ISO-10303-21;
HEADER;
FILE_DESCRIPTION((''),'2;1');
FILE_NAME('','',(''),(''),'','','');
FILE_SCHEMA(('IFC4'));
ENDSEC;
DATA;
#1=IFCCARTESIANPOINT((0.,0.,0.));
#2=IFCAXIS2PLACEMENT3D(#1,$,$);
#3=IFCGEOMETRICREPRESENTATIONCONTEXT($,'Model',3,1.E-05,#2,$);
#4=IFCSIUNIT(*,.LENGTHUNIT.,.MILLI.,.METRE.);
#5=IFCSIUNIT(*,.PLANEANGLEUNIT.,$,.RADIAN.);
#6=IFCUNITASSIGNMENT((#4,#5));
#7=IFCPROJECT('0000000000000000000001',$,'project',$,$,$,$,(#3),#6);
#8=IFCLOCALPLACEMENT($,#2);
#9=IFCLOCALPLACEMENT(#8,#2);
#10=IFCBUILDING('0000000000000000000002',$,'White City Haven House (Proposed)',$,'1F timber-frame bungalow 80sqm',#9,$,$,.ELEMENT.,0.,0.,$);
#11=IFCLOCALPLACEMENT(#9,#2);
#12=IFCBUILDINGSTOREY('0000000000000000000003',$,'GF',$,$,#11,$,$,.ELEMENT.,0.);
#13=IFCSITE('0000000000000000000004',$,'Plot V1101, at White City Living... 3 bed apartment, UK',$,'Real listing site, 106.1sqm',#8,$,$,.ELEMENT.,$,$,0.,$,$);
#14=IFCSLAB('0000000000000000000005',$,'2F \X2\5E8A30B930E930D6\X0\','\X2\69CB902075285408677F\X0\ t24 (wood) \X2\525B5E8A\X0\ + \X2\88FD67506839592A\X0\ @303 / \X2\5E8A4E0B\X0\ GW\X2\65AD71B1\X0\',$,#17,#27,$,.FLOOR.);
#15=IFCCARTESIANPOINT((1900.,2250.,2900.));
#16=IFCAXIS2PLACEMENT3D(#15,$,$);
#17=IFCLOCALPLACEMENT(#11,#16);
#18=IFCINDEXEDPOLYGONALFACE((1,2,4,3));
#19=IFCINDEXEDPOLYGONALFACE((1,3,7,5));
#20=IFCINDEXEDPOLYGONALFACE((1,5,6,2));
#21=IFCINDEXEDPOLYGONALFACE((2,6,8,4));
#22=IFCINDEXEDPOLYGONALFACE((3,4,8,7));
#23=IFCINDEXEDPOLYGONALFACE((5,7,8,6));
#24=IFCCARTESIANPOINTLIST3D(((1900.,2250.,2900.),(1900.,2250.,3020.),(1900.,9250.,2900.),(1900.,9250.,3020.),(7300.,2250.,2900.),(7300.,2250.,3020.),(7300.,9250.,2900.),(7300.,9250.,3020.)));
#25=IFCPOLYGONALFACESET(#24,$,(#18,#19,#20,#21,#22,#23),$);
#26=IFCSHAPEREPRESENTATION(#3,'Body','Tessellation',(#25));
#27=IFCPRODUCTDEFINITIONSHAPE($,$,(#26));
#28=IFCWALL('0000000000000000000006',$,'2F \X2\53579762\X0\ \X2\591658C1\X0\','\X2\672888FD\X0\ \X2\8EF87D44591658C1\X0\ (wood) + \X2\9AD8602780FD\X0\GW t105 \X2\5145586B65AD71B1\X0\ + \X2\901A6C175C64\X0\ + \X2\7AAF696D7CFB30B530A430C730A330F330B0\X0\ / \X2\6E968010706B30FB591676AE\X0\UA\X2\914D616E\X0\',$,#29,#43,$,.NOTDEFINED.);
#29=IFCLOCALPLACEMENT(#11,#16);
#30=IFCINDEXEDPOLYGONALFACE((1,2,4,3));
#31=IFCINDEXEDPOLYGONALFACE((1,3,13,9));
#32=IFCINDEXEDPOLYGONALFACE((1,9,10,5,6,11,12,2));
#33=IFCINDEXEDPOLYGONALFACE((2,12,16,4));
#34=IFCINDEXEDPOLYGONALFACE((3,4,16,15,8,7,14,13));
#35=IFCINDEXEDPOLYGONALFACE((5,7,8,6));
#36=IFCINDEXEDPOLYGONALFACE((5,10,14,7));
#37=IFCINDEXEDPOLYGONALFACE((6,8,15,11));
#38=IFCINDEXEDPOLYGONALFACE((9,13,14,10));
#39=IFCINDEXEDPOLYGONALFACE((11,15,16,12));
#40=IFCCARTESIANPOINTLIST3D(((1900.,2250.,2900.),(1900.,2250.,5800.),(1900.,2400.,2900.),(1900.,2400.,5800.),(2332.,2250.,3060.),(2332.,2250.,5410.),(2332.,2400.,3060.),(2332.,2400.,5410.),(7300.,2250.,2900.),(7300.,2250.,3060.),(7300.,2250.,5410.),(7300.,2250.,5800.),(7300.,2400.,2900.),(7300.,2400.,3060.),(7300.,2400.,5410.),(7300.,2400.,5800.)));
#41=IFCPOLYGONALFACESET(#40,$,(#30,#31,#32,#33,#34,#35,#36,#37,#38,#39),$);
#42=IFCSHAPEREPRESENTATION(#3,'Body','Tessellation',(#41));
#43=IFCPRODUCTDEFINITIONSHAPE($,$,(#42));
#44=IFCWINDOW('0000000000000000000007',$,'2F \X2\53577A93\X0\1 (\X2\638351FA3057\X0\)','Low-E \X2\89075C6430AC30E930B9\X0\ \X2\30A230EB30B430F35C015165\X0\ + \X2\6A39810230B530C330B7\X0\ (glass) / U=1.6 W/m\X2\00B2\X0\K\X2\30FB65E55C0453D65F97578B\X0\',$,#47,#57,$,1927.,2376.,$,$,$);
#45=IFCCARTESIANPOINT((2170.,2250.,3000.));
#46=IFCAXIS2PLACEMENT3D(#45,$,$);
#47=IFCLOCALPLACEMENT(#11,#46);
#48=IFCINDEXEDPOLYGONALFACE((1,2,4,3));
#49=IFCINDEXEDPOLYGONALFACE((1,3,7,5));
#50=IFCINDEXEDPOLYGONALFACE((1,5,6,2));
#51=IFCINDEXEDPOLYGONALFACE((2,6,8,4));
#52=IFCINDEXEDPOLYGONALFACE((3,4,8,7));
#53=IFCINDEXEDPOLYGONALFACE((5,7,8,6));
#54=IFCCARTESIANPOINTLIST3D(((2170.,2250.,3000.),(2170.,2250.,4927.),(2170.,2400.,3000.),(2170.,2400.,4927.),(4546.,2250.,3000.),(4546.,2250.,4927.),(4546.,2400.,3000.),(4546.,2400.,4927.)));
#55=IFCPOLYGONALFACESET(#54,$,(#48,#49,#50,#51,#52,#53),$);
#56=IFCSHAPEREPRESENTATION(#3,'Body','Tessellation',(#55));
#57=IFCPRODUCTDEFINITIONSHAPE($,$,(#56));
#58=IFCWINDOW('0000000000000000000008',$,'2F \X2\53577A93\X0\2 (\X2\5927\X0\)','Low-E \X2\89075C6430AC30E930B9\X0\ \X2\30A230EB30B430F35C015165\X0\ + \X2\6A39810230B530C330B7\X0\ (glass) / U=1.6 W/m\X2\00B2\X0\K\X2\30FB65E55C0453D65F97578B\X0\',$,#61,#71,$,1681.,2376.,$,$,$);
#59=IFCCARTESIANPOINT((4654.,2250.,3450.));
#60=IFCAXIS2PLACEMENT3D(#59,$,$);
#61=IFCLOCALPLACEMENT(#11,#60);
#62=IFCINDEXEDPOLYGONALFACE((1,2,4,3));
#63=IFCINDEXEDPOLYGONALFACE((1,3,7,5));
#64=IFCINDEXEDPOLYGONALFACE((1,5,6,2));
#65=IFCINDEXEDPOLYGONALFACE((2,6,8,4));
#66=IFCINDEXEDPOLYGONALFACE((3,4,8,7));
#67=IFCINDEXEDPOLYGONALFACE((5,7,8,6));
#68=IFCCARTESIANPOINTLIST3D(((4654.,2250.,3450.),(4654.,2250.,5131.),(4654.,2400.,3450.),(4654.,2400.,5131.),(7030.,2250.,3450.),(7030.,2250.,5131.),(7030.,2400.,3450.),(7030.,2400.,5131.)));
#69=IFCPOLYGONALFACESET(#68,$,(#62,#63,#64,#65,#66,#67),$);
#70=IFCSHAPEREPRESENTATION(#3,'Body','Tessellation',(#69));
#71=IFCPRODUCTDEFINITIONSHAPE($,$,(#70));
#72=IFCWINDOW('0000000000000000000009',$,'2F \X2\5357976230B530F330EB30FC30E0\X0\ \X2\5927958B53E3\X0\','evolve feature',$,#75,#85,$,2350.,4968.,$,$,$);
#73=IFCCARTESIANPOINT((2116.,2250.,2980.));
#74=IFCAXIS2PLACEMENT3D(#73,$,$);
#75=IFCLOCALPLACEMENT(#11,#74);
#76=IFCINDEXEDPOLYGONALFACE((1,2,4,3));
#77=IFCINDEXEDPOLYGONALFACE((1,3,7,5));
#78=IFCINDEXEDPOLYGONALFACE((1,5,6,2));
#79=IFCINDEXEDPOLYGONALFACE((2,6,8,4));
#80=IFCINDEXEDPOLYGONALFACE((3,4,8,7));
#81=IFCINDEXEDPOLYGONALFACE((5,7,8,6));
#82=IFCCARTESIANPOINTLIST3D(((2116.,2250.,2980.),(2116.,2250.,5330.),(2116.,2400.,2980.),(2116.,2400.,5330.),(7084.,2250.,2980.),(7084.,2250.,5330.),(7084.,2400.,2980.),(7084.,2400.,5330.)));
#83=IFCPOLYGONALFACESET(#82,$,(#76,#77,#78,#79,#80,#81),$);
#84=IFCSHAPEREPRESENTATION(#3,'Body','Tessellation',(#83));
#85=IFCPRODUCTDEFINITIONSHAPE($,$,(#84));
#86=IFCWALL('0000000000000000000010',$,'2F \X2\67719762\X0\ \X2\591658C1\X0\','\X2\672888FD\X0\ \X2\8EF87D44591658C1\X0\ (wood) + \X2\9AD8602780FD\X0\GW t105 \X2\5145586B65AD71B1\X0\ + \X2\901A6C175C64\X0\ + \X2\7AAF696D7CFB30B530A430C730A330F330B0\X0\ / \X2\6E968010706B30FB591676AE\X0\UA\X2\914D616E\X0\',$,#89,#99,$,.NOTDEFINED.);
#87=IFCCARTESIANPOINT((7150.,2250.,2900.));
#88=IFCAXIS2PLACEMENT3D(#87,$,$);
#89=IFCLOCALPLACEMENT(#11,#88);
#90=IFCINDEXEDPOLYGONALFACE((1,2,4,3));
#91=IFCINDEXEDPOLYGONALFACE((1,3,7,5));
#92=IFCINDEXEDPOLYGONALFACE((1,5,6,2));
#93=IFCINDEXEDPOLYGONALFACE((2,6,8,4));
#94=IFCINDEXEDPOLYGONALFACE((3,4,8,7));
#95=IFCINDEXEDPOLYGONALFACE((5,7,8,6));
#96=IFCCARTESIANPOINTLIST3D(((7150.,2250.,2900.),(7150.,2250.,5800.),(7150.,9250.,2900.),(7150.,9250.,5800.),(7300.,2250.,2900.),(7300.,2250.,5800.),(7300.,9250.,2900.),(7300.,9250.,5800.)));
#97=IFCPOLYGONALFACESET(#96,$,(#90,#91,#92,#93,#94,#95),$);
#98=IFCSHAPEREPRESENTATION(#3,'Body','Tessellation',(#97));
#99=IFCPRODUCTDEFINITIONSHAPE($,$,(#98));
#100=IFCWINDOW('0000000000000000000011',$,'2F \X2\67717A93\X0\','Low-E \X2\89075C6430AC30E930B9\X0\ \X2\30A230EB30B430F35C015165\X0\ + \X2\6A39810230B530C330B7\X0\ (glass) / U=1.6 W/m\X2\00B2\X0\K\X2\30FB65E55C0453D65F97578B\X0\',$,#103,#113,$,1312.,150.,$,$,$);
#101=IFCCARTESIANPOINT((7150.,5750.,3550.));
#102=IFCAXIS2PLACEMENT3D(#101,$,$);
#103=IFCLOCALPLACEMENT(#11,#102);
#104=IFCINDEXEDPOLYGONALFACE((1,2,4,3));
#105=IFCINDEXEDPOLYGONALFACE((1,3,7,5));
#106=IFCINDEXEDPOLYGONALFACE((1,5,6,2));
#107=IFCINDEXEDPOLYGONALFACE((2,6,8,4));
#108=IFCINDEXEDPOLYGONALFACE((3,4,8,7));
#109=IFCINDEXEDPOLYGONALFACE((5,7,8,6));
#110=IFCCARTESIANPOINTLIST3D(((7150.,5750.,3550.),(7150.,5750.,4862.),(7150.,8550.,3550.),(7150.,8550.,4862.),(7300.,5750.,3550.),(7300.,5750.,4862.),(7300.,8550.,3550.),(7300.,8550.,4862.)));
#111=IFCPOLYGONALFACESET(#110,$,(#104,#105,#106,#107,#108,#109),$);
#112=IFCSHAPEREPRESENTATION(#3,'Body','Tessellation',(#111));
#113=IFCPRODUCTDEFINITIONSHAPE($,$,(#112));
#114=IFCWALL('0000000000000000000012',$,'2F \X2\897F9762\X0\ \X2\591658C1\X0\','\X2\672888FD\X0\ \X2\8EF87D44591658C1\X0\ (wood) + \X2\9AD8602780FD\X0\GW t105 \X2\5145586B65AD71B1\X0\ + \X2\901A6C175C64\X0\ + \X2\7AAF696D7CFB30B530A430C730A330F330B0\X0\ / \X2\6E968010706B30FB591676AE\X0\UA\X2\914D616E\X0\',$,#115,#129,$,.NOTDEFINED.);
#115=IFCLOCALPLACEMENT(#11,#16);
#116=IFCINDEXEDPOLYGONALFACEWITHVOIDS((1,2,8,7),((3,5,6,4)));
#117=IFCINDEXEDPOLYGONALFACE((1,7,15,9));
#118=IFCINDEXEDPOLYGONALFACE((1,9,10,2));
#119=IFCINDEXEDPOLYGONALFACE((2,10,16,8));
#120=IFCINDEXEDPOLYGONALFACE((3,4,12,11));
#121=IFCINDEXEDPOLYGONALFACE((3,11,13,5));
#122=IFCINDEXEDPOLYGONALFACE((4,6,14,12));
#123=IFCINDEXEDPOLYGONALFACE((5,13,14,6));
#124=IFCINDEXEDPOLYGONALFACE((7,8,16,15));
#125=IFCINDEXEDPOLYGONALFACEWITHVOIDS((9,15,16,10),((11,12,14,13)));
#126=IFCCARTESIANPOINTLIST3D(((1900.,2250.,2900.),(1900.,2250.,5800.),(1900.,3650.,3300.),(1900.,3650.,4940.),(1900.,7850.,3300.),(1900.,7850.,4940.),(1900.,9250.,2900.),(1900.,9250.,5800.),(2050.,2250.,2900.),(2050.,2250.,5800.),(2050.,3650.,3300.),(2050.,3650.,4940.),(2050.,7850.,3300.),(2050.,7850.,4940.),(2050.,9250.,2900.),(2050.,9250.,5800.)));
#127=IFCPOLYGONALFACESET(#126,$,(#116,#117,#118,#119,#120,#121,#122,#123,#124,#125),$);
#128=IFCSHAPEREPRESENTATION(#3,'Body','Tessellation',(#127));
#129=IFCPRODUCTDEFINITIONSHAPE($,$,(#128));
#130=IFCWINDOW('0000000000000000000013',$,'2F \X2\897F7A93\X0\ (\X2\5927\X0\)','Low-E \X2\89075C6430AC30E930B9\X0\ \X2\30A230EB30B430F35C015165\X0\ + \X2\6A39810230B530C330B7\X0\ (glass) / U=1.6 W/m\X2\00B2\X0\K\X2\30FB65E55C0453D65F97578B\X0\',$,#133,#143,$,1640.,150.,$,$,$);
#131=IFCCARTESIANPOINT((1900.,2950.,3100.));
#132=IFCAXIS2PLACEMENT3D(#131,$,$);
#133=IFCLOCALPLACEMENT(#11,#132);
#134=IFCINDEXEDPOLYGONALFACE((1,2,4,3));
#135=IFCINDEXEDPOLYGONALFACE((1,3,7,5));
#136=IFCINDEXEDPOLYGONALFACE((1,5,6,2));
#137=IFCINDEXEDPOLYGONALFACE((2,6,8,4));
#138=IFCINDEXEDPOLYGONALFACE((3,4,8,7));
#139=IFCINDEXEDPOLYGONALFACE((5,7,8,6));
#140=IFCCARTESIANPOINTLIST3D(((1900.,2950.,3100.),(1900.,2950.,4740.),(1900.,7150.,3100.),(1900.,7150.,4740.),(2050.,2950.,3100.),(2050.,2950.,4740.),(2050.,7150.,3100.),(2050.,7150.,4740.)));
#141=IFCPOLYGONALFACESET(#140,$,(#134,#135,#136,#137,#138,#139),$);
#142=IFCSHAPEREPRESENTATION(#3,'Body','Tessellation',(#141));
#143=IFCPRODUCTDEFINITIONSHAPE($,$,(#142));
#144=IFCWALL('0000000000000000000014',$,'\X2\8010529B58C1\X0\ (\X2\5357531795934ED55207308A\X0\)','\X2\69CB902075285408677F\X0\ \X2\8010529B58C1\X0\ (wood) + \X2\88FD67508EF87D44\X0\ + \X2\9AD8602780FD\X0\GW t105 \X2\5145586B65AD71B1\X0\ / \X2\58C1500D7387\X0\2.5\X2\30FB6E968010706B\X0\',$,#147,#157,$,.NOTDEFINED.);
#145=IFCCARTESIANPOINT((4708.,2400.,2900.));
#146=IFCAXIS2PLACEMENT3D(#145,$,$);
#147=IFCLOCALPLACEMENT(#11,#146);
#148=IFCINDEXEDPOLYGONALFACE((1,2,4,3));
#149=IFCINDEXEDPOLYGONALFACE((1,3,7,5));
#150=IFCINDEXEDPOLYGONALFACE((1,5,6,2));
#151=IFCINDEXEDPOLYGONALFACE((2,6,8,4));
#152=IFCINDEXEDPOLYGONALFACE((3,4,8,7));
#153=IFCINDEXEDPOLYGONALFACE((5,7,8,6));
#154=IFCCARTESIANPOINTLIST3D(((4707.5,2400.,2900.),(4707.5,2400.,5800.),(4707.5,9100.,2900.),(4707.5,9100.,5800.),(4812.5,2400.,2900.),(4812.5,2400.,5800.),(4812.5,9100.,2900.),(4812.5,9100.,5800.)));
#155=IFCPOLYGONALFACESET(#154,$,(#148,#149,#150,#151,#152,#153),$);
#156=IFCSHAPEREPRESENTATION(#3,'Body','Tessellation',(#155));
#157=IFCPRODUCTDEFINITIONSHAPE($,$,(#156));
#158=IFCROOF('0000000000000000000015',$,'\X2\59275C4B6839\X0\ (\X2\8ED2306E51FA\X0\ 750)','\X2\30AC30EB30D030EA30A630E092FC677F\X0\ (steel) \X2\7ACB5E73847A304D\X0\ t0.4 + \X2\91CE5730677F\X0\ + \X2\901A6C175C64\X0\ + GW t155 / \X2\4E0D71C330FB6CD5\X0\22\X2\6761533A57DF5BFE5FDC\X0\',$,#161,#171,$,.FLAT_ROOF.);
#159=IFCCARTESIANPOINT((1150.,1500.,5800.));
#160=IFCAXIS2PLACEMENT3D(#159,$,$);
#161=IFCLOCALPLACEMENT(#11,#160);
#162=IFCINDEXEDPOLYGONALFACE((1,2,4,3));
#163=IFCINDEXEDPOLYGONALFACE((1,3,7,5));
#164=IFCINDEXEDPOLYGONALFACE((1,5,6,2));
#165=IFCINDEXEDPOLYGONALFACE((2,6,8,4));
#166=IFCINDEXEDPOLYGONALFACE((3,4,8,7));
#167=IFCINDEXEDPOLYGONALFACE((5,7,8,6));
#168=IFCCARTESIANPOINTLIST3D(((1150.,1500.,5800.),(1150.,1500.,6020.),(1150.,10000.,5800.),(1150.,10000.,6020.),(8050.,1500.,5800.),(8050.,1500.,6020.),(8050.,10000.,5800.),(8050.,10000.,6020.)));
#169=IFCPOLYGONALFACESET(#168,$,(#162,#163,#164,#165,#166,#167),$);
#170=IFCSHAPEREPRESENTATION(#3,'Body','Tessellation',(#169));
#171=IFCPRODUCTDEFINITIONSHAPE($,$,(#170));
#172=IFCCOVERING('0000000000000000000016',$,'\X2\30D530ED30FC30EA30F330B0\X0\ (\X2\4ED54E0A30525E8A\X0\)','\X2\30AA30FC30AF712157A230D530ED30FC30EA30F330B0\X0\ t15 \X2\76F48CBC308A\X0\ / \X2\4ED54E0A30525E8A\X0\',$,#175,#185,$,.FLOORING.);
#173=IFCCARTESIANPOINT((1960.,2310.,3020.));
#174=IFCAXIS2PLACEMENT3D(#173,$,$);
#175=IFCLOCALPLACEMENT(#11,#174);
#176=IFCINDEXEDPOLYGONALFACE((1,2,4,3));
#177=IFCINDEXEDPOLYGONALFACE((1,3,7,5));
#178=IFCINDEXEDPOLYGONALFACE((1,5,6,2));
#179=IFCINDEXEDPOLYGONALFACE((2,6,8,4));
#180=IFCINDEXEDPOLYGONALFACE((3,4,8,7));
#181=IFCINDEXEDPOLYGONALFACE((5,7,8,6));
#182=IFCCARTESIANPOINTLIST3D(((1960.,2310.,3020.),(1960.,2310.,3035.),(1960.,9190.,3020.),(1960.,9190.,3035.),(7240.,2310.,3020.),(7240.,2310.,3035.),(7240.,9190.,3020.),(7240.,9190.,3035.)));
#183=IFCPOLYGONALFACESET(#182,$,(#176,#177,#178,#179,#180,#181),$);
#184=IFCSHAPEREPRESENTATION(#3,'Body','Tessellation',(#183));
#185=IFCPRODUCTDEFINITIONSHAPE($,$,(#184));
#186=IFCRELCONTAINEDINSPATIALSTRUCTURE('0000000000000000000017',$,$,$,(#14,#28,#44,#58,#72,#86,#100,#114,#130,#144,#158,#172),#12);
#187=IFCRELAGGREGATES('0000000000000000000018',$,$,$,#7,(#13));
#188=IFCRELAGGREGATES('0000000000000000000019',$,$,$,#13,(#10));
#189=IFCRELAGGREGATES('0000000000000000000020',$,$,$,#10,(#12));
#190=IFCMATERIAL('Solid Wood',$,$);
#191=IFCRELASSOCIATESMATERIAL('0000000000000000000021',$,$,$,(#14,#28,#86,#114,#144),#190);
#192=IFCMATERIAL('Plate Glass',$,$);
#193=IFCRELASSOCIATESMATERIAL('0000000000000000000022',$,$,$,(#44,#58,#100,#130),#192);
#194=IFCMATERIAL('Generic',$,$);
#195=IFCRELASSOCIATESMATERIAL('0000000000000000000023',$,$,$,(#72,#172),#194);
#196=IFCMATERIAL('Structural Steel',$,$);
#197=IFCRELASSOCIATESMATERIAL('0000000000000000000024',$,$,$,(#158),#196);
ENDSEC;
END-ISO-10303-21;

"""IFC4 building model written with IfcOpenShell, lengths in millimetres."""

from ifc_helpers import new_model, si_unit, frame, frame_2d, origin, place, context, project, spatial, rectangle, extrude, material, element, fill, save


model = new_model("IFC4")

# Units and contexts
model_context = context("Model", 3, precision=1e-05, world=origin())
ifc_project = project(units=[si_unit("LENGTHUNIT", "METRE", prefix="MILLI"), si_unit("PLANEANGLEUNIT", "RADIAN")], contexts=[model_context])

# Site, building, storey
site_placement = place(None, origin())
site = spatial("IfcSite", under=ifc_project, at=site_placement, Name="Plot V1101, at White City Living... 3 bed apartment, UK", ObjectType="Real listing site, 106.1sqm", CompositionType="ELEMENT", RefElevation=0.0)
building_placement = place(site_placement, origin())
building = spatial("IfcBuilding", under=site, at=building_placement, Name="White City Haven House (Proposed)", ObjectType="1F timber-frame bungalow 80sqm", CompositionType="ELEMENT", ElevationOfRefHeight=0.0, ElevationOfTerrain=0.0)
storey_placement = place(building_placement, origin())
storey = spatial("IfcBuildingStorey", under=building, at=storey_placement, Name="GF", CompositionType="ELEMENT", Elevation=0.0)

# Slab
ifc_material_1 = material(Name="Solid Wood")
slab_placement = place(storey_placement, frame((1900.0, 2250.0, 2900.0)))
element("IfcSlab", 1, at=slab_placement, inside=storey, material=ifc_material_1, Name="2F 床スラブ", Description="構造用合板 t24 (wood) 剛床 + 製材根太 @303 / 床下 GW断熱", PredefinedType="FLOOR", context=model_context, shape_type="SweptSolid", body=[
    extrude(rectangle(XDim=5400.0, YDim=7000.0, at=frame_2d((2700.0, 3500.0))), frame((1900.0, 2250.0, 2900.0)), (0.0, 0.0, 1.0), 120.0),
])

# Wall, openings, windows
wall_1_placement = place(storey_placement, frame((1900.0, 2250.0, 2900.0)))
wall_1 = element("IfcWall", 2, at=wall_1_placement, inside=storey, material=ifc_material_1, Name="2F 南面 外壁", Description="木製 軸組外壁 (wood) + 高性能GW t105 充填断熱 + 通気層 + 窯業系サイディング / 準耐火・外皮UA配慮", PredefinedType="NOTDEFINED", context=model_context, shape_type="SweptSolid", body=[
    extrude(rectangle(XDim=5400.0, YDim=150.0, at=frame_2d((2700.0, 75.0))), frame((1900.0, 2250.0, 2900.0)), (0.0, 0.0, 1.0), 2900.0),
])
opening_1_placement = place(storey_placement, frame((2170.0, 2250.0, 3000.0)))
opening_1 = element("IfcOpeningElement", 3, at=opening_1_placement, cuts=wall_1, PredefinedType="NOTDEFINED", context=model_context, shape_type="SweptSolid", body=[
    extrude(rectangle(XDim=2376.0, YDim=150.0, at=frame_2d((1188.0, 75.0))), frame((2170.0, 2250.0, 3000.0)), (0.0, 0.0, 1.0), 1927.0),
])
opening_2_placement = place(storey_placement, frame((4654.0, 2250.0, 3450.0)))
opening_2 = element("IfcOpeningElement", 4, at=opening_2_placement, cuts=wall_1, PredefinedType="NOTDEFINED", context=model_context, shape_type="SweptSolid", body=[
    extrude(rectangle(XDim=2376.0, YDim=150.0, at=frame_2d((1188.0, 75.0))), frame((4654.0, 2250.0, 3450.0)), (0.0, 0.0, 1.0), 1681.0),
])
opening_3_placement = place(storey_placement, frame((2116.0, 2250.0, 2980.0)))
opening_3 = element("IfcOpeningElement", 5, at=opening_3_placement, cuts=wall_1, PredefinedType="NOTDEFINED", context=model_context, shape_type="SweptSolid", body=[
    extrude(rectangle(XDim=4968.0, YDim=150.0, at=frame_2d((2484.0, 75.0))), frame((2116.0, 2250.0, 2980.0)), (0.0, 0.0, 1.0), 2350.0),
])
ifc_material_2 = material(Name="Plate Glass")
window_1_placement = place(storey_placement, frame((2170.0, 2250.0, 3000.0)))
window_1 = element("IfcWindow", 6, at=window_1_placement, inside=storey, material=ifc_material_2, Name="2F 南窓1 (掃出し)", Description="Low-E 複層ガラス アルゴン封入 + 樹脂サッシ (glass) / U=1.6 W/m²K・日射取得型", OverallHeight=1927.0, OverallWidth=2376.0, context=model_context, shape_type="SweptSolid", body=[
    extrude(rectangle(XDim=2376.0, YDim=150.0, at=frame_2d((1188.0, 75.0))), frame((2170.0, 2250.0, 3000.0)), (0.0, 0.0, 1.0), 1927.0),
])
fill(opening_1, window_1)
window_2_placement = place(storey_placement, frame((4654.0, 2250.0, 3450.0)))
window_2 = element("IfcWindow", 7, at=window_2_placement, inside=storey, material=ifc_material_2, Name="2F 南窓2 (大)", Description="Low-E 複層ガラス アルゴン封入 + 樹脂サッシ (glass) / U=1.6 W/m²K・日射取得型", OverallHeight=1681.0, OverallWidth=2376.0, context=model_context, shape_type="SweptSolid", body=[
    extrude(rectangle(XDim=2376.0, YDim=150.0, at=frame_2d((1188.0, 75.0))), frame((4654.0, 2250.0, 3450.0)), (0.0, 0.0, 1.0), 1681.0),
])
fill(opening_2, window_2)
ifc_material_3 = material(Name="Generic")
window_3_placement = place(storey_placement, frame((2116.0, 2250.0, 2980.0)))
window_3 = element("IfcWindow", 8, at=window_3_placement, inside=storey, material=ifc_material_3, Name="2F 南面サンルーム 大開口", Description="evolve feature", OverallHeight=2350.0, OverallWidth=4968.0, context=model_context, shape_type="SweptSolid", body=[
    extrude(rectangle(XDim=4968.0, YDim=150.0, at=frame_2d((2484.0, 75.0))), frame((2116.0, 2250.0, 2980.0)), (0.0, 0.0, 1.0), 2350.0),
])
fill(opening_3, window_3)

# Walls, openings, windows
wall_2_placement = place(storey_placement, frame((7150.0, 2250.0, 2900.0)))
wall_2 = element("IfcWall", 9, at=wall_2_placement, inside=storey, material=ifc_material_1, Name="2F 東面 外壁", Description="木製 軸組外壁 (wood) + 高性能GW t105 充填断熱 + 通気層 + 窯業系サイディング / 準耐火・外皮UA配慮", PredefinedType="NOTDEFINED", context=model_context, shape_type="SweptSolid", body=[
    extrude(rectangle(XDim=150.0, YDim=7000.0, at=frame_2d((75.0, 3500.0))), frame((7150.0, 2250.0, 2900.0)), (0.0, 0.0, 1.0), 2900.0),
])
opening_4_placement = place(storey_placement, frame((7150.0, 5750.0, 3550.0)))
opening_4 = element("IfcOpeningElement", 10, at=opening_4_placement, cuts=wall_2, PredefinedType="NOTDEFINED", context=model_context, shape_type="SweptSolid", body=[
    extrude(rectangle(XDim=150.0, YDim=2800.0, at=frame_2d((75.0, 1400.0))), frame((7150.0, 5750.0, 3550.0)), (0.0, 0.0, 1.0), 1312.0),
])
window_4_placement = place(storey_placement, frame((7150.0, 5750.0, 3550.0)))
window_4 = element("IfcWindow", 11, at=window_4_placement, inside=storey, material=ifc_material_2, Name="2F 東窓", Description="Low-E 複層ガラス アルゴン封入 + 樹脂サッシ (glass) / U=1.6 W/m²K・日射取得型", OverallHeight=1312.0, OverallWidth=150.0, context=model_context, shape_type="SweptSolid", body=[
    extrude(rectangle(XDim=150.0, YDim=2800.0, at=frame_2d((75.0, 1400.0))), frame((7150.0, 5750.0, 3550.0)), (0.0, 0.0, 1.0), 1312.0),
])
fill(opening_4, window_4)
wall_3_placement = place(storey_placement, frame((1900.0, 2250.0, 2900.0)))
wall_3 = element("IfcWall", 12, at=wall_3_placement, inside=storey, material=ifc_material_1, Name="2F 西面 外壁", Description="木製 軸組外壁 (wood) + 高性能GW t105 充填断熱 + 通気層 + 窯業系サイディング / 準耐火・外皮UA配慮", PredefinedType="NOTDEFINED", context=model_context, shape_type="SweptSolid", body=[
    extrude(rectangle(XDim=150.0, YDim=7000.0, at=frame_2d((75.0, 3500.0))), frame((1900.0, 2250.0, 2900.0)), (0.0, 0.0, 1.0), 2900.0),
])
opening_5_placement = place(storey_placement, frame((1900.0, 2950.0, 3100.0)))
opening_5 = element("IfcOpeningElement", 13, at=opening_5_placement, cuts=wall_3, PredefinedType="NOTDEFINED", context=model_context, shape_type="SweptSolid", body=[
    extrude(rectangle(XDim=150.0, YDim=4200.0, at=frame_2d((75.0, 2100.0))), frame((1900.0, 2950.0, 3100.0)), (0.0, 0.0, 1.0), 1640.0),
])
window_5_placement = place(storey_placement, frame((1900.0, 2950.0, 3100.0)))
window_5 = element("IfcWindow", 14, at=window_5_placement, inside=storey, material=ifc_material_2, Name="2F 西窓 (大)", Description="Low-E 複層ガラス アルゴン封入 + 樹脂サッシ (glass) / U=1.6 W/m²K・日射取得型", OverallHeight=1640.0, OverallWidth=150.0, context=model_context, shape_type="SweptSolid", body=[
    extrude(rectangle(XDim=150.0, YDim=4200.0, at=frame_2d((75.0, 2100.0))), frame((1900.0, 2950.0, 3100.0)), (0.0, 0.0, 1.0), 1640.0),
])
fill(opening_5, window_5)

# Wall
wall_4_placement = place(storey_placement, frame((4708.0, 2400.0, 2900.0)))
element("IfcWall", 15, at=wall_4_placement, inside=storey, material=ifc_material_1, Name="耐力壁 (南北間仕切り)", Description="構造用合板 耐力壁 (wood) + 製材軸組 + 高性能GW t105 充填断熱 / 壁倍率2.5・準耐火", PredefinedType="NOTDEFINED", context=model_context, shape_type="SweptSolid", body=[
    extrude(rectangle(XDim=105.0, YDim=6700.0, at=frame_2d((52.0, 3350.0))), frame((4708.0, 2400.0, 2900.0)), (0.0, 0.0, 1.0), 2900.0),
])

# Roof
ifc_material_4 = material(Name="Structural Steel")
roof_placement = place(storey_placement, frame((1150.0, 1500.0, 5800.0)))
element("IfcRoof", 16, at=roof_placement, inside=storey, material=ifc_material_4, Name="大屋根 (軒の出 750)", Description="ガルバリウム鋼板 (steel) 立平葺き t0.4 + 野地板 + 通気層 + GW t155 / 不燃・法22条区域対応", PredefinedType="FLAT_ROOF", context=model_context, shape_type="SweptSolid", body=[
    extrude(rectangle(XDim=6900.0, YDim=8500.0, at=frame_2d((3450.0, 4250.0))), frame((1150.0, 1500.0, 5800.0)), (0.0, 0.0, 1.0), 220.0),
])

# Covering
covering_placement = place(storey_placement, frame((1960.0, 2310.0, 3020.0)))
element("IfcCovering", 17, at=covering_placement, inside=storey, material=ifc_material_3, Name="フローリング (仕上げ床)", Description="オーク無垢フローリング t15 直貼り / 仕上げ床", PredefinedType="FLOORING", context=model_context, shape_type="SweptSolid", body=[
    extrude(rectangle(XDim=5280.0, YDim=6880.0, at=frame_2d((2640.0, 3440.0))), frame((1960.0, 2310.0, 3020.0)), (0.0, 0.0, 1.0), 15.0),
])

save(model, "model.ifc")
